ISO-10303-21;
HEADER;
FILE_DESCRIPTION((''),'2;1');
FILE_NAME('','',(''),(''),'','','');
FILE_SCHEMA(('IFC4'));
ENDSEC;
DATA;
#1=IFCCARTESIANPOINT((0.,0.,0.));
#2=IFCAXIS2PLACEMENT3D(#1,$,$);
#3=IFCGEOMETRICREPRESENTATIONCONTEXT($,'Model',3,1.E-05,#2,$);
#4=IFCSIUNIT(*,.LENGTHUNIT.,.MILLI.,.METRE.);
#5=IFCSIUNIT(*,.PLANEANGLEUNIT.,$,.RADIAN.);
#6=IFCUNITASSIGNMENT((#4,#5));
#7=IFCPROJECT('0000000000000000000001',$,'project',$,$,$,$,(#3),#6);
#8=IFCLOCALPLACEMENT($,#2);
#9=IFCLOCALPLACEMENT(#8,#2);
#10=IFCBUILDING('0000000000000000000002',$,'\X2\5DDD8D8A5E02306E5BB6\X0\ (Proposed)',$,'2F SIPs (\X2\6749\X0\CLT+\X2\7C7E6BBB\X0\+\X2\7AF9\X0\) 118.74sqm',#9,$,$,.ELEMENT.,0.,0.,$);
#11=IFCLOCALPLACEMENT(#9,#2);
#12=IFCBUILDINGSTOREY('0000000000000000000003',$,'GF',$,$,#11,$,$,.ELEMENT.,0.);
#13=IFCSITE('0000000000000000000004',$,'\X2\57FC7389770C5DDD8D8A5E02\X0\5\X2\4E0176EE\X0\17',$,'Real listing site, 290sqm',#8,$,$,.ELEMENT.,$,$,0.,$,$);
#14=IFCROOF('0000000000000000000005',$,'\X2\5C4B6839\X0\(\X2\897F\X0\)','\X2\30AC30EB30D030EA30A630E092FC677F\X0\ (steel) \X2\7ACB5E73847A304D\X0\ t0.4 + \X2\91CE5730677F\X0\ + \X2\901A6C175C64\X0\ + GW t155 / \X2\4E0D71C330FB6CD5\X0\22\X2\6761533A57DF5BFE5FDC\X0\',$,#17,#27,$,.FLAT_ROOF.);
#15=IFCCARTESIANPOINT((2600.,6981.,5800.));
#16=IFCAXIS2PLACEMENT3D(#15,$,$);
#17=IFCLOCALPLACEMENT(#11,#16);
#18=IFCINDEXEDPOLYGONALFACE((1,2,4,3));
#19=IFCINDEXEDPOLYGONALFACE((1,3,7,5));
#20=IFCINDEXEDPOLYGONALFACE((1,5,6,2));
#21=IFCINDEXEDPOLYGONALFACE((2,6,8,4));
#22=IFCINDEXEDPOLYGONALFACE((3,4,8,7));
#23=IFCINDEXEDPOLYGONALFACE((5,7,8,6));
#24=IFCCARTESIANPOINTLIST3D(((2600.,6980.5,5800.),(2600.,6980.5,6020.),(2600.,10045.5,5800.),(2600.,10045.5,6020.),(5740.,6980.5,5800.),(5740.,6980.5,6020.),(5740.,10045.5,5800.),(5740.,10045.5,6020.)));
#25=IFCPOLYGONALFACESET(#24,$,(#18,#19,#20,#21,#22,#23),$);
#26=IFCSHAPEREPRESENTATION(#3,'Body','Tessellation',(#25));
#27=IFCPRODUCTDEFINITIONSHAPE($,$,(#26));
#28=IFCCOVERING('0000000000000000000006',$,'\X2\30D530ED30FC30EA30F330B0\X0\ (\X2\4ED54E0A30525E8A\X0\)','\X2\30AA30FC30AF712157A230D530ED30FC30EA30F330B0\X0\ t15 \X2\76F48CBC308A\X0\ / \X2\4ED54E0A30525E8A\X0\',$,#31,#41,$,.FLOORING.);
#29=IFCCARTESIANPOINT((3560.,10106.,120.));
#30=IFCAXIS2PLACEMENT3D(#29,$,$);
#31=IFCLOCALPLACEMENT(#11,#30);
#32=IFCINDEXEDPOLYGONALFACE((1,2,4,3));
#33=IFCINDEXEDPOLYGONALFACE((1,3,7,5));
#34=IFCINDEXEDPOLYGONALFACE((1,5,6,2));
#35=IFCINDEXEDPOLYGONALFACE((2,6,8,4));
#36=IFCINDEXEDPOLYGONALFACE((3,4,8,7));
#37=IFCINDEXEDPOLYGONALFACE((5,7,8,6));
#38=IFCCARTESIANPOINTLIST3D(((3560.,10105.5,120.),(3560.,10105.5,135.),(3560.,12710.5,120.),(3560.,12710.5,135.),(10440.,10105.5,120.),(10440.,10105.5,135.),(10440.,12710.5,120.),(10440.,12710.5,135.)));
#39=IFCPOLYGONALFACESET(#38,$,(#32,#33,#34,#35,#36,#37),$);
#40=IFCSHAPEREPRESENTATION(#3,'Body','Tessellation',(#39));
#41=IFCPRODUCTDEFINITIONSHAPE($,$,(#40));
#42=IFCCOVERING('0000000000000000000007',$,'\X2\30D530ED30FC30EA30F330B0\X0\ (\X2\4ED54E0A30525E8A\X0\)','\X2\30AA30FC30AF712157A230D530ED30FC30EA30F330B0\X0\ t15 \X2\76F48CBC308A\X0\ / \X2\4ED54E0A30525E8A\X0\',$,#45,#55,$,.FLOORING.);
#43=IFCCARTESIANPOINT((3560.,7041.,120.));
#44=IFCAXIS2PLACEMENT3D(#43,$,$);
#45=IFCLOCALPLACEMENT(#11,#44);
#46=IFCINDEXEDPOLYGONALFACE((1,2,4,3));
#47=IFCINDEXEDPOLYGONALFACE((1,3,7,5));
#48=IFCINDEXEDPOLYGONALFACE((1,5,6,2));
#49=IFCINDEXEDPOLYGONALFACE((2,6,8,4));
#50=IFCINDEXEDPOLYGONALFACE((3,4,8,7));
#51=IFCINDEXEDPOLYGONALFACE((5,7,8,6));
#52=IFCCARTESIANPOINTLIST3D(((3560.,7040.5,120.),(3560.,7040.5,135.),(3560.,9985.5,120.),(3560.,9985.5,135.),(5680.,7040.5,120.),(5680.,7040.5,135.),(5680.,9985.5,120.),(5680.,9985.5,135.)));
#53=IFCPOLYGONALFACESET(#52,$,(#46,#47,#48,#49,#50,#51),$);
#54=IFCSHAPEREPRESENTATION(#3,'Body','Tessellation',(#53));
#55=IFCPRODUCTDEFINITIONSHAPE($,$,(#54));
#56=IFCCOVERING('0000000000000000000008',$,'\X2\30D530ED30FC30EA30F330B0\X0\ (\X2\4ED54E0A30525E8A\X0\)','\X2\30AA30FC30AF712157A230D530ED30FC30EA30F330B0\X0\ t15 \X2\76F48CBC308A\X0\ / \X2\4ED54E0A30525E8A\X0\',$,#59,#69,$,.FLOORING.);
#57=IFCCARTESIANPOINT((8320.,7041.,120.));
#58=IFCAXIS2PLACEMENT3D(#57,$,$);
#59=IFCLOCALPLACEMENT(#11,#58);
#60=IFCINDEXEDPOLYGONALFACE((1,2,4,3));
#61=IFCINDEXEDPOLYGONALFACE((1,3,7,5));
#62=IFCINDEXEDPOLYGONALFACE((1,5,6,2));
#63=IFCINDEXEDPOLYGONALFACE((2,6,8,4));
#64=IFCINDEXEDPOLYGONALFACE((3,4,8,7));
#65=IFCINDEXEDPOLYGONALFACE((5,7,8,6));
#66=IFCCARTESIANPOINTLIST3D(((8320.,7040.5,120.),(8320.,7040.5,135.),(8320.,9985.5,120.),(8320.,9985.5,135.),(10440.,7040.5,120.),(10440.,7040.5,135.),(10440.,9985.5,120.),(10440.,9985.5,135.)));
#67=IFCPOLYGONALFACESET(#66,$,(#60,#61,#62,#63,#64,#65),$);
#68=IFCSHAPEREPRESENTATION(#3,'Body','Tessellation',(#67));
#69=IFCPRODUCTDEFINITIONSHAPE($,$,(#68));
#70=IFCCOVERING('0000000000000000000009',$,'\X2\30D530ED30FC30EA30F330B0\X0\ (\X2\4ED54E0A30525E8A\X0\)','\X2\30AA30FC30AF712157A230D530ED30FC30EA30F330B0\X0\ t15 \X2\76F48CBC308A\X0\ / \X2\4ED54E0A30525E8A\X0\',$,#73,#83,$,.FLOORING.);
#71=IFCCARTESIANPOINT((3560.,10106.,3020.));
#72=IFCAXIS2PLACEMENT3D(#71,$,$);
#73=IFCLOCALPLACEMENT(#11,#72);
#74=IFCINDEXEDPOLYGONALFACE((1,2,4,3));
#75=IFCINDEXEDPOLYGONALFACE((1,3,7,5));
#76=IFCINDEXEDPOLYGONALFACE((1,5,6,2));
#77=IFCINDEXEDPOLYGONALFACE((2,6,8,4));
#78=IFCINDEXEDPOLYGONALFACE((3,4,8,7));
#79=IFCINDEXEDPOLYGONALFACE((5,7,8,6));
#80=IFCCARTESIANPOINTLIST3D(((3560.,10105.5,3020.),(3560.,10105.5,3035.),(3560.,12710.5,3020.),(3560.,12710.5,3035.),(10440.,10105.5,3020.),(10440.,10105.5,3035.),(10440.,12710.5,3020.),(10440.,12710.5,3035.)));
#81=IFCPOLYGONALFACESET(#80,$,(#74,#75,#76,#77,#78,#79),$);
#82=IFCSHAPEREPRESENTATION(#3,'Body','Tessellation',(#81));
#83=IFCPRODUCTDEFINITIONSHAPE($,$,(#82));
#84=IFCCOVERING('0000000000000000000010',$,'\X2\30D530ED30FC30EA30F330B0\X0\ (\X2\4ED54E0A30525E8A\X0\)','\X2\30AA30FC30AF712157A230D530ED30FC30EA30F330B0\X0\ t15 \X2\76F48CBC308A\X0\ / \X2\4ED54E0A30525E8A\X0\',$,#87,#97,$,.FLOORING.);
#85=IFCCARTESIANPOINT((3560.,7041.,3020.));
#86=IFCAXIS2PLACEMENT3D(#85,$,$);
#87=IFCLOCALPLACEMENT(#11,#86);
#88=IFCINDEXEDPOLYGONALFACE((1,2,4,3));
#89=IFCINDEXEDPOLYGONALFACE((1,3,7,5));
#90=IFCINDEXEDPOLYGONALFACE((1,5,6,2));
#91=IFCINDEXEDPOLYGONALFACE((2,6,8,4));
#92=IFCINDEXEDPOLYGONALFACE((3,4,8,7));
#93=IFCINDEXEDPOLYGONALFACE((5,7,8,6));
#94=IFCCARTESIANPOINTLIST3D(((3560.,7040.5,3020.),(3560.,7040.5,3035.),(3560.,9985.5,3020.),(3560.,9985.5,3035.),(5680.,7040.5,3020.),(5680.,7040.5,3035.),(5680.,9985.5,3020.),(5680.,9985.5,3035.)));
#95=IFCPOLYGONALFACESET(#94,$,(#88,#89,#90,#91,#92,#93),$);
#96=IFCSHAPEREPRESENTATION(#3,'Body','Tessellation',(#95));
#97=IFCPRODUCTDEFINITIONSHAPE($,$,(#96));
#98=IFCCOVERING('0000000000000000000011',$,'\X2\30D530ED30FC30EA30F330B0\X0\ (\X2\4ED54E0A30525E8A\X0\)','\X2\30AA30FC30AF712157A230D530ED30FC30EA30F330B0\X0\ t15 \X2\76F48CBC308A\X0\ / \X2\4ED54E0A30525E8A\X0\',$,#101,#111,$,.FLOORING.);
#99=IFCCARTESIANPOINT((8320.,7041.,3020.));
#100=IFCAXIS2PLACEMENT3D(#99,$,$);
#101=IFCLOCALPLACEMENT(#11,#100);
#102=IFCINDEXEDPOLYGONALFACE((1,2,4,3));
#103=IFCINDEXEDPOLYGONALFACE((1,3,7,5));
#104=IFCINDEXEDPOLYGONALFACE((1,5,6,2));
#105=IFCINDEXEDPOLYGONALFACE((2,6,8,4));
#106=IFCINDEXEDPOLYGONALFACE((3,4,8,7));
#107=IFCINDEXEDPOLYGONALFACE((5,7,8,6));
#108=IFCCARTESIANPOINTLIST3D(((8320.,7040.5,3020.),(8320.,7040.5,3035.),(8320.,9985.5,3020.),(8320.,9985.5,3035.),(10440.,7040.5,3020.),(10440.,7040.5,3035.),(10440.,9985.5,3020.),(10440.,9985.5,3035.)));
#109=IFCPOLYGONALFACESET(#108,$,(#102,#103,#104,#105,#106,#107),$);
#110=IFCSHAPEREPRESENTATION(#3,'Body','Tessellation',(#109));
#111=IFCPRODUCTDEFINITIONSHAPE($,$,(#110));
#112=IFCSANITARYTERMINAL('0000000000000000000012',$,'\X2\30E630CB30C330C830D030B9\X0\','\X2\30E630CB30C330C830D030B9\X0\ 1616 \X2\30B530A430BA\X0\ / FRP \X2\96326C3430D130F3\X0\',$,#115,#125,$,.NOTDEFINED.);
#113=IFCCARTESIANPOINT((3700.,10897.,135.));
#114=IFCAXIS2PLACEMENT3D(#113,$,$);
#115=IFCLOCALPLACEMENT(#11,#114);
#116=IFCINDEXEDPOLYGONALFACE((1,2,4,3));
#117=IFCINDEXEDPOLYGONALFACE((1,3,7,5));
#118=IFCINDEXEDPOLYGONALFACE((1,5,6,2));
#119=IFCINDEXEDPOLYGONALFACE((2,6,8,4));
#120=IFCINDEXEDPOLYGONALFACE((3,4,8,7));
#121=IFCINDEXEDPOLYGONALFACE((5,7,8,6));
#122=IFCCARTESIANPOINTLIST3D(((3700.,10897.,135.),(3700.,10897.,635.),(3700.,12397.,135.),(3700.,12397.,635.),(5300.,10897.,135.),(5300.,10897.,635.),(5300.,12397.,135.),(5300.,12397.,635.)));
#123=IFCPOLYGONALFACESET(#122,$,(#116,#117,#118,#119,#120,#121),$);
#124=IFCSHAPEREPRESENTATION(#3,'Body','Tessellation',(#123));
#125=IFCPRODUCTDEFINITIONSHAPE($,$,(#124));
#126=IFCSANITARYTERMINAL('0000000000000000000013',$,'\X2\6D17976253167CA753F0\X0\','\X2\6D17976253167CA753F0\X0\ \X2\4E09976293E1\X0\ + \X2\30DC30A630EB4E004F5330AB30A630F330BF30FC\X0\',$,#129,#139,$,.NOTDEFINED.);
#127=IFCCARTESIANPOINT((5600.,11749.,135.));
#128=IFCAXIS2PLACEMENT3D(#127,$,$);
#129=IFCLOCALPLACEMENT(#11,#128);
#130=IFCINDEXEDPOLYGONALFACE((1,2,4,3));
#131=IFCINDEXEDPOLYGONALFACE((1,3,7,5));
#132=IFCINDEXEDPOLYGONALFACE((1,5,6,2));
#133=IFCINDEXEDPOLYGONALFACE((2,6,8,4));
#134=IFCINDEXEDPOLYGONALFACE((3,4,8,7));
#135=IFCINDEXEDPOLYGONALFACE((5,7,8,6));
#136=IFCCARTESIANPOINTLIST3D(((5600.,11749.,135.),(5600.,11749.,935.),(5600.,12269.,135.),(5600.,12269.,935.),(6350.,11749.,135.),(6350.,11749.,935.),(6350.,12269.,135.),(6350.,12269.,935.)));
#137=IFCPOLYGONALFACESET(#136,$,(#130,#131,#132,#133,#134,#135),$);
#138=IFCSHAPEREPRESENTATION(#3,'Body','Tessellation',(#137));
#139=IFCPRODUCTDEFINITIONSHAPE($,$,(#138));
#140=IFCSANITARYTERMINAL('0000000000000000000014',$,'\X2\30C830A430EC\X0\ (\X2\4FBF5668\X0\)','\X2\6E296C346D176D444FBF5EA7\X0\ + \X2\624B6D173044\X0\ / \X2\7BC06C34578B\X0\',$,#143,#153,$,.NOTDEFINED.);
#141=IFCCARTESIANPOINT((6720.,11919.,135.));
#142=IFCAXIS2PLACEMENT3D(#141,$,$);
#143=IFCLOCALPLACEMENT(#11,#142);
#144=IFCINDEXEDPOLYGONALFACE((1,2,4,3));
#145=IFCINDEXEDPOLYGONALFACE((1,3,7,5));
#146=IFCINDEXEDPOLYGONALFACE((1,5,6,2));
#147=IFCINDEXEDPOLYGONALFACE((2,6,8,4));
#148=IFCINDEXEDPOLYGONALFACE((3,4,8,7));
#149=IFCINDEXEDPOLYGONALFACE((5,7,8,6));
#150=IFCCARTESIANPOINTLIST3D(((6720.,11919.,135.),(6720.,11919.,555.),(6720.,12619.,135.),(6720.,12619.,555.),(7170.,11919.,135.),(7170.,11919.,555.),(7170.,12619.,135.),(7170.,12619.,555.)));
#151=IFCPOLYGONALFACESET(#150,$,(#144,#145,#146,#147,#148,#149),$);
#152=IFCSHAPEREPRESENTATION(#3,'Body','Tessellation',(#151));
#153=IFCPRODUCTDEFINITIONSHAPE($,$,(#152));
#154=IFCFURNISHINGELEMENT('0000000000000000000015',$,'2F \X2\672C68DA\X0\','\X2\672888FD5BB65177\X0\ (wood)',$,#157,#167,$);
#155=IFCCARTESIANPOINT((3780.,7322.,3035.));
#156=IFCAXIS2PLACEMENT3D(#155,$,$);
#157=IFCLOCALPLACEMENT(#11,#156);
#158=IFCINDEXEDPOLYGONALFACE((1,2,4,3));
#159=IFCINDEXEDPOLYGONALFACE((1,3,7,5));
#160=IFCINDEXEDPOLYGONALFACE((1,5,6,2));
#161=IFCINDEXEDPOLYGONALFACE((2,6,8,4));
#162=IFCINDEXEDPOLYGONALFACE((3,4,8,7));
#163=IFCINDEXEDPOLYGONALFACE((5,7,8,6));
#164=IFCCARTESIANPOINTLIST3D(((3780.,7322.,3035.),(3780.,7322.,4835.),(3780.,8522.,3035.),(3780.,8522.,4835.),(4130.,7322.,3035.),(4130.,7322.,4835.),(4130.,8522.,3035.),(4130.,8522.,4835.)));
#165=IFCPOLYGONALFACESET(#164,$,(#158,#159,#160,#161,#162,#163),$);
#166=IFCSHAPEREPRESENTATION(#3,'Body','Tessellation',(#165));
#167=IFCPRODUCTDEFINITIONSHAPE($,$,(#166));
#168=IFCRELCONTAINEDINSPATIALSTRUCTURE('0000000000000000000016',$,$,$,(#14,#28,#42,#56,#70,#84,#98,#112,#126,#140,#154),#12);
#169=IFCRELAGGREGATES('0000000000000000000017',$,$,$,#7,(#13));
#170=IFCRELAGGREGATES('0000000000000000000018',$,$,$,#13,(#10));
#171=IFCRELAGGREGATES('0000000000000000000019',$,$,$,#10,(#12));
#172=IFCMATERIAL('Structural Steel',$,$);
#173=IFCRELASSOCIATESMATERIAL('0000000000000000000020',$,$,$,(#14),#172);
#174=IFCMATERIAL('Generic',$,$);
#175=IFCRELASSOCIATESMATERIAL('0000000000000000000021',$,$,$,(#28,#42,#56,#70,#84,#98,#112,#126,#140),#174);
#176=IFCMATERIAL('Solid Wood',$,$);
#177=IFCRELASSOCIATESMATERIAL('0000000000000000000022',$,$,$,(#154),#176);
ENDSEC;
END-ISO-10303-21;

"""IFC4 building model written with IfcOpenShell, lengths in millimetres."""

from ifc_helpers import new_model, si_unit, frame, frame_2d, origin, place, context, project, spatial, rectangle, extrude, material, element, save


model = new_model("IFC4")

# Units and contexts
model_context = context("Model", 3, precision=1e-05, world=origin())
ifc_project = project(units=[si_unit("LENGTHUNIT", "METRE", prefix="MILLI"), si_unit("PLANEANGLEUNIT", "RADIAN")], contexts=[model_context])

# Site, building, storey
site_placement = place(None, origin())
site = spatial("IfcSite", under=ifc_project, at=site_placement, Name="埼玉県川越市5丁目17", ObjectType="Real listing site, 290sqm", CompositionType="ELEMENT", RefElevation=0.0)
building_placement = place(site_placement, origin())
building = spatial("IfcBuilding", under=site, at=building_placement, Name="川越市の家 (Proposed)", ObjectType="2F SIPs (杉CLT+籾殻+竹) 118.74sqm", CompositionType="ELEMENT", ElevationOfRefHeight=0.0, ElevationOfTerrain=0.0)
storey_placement = place(building_placement, origin())
storey = spatial("IfcBuildingStorey", under=building, at=storey_placement, Name="GF", CompositionType="ELEMENT", Elevation=0.0)

# Shared definitions
ifc_material_1 = material(Name="Solid Wood")

# Shared definitions
ifc_material_2 = material(Name="Generic")

# Roof
ifc_material_3 = material(Name="Structural Steel")
roof_1_placement = place(storey_placement, frame((2600.0, 6981.0, 5800.0)))
element("IfcRoof", 1, at=roof_1_placement, inside=storey, material=ifc_material_3, Name="屋根(西)", Description="ガルバリウム鋼板 (steel) 立平葺き t0.4 + 野地板 + 通気層 + GW t155 / 不燃・法22条区域対応", PredefinedType="FLAT_ROOF", context=model_context, shape_type="SweptSolid", body=[
    extrude(rectangle(XDim=3140.0, YDim=3065.0, at=frame_2d((1570.0, 1532.0))), frame((2600.0, 6981.0, 5800.0)), (0.0, 0.0, 1.0), 220.0),
])

# Coverings
covering_1_placement = place(storey_placement, frame((3560.0, 10106.0, 120.0)))
element("IfcCovering", 2, at=covering_1_placement, inside=storey, material=ifc_material_2, Name="フローリング (仕上げ床)", Description="オーク無垢フローリング t15 直貼り / 仕上げ床", PredefinedType="FLOORING", context=model_context, shape_type="SweptSolid", body=[
    extrude(rectangle(XDim=6880.0, YDim=2605.0, at=frame_2d((3440.0, 1302.0))), frame((3560.0, 10106.0, 120.0)), (0.0, 0.0, 1.0), 15.0),
])
covering_2_placement = place(storey_placement, frame((3560.0, 7041.0, 120.0)))
element("IfcCovering", 3, at=covering_2_placement, inside=storey, material=ifc_material_2, Name="フローリング (仕上げ床)", Description="オーク無垢フローリング t15 直貼り / 仕上げ床", PredefinedType="FLOORING", context=model_context, shape_type="SweptSolid", body=[
    extrude(rectangle(XDim=2120.0, YDim=2945.0, at=frame_2d((1060.0, 1472.0))), frame((3560.0, 7041.0, 120.0)), (0.0, 0.0, 1.0), 15.0),
])
covering_3_placement = place(storey_placement, frame((8320.0, 7041.0, 120.0)))
element("IfcCovering", 4, at=covering_3_placement, inside=storey, material=ifc_material_2, Name="フローリング (仕上げ床)", Description="オーク無垢フローリング t15 直貼り / 仕上げ床", PredefinedType="FLOORING", context=model_context, shape_type="SweptSolid", body=[
    extrude(rectangle(XDim=2120.0, YDim=2945.0, at=frame_2d((1060.0, 1472.0))), frame((8320.0, 7041.0, 120.0)), (0.0, 0.0, 1.0), 15.0),
])
covering_4_placement = place(storey_placement, frame((3560.0, 10106.0, 3020.0)))
element("IfcCovering", 5, at=covering_4_placement, inside=storey, material=ifc_material_2, Name="フローリング (仕上げ床)", Description="オーク無垢フローリング t15 直貼り / 仕上げ床", PredefinedType="FLOORING", context=model_context, shape_type="SweptSolid", body=[
    extrude(rectangle(XDim=6880.0, YDim=2605.0, at=frame_2d((3440.0, 1302.0))), frame((3560.0, 10106.0, 3020.0)), (0.0, 0.0, 1.0), 15.0),
])
covering_5_placement = place(storey_placement, frame((3560.0, 7041.0, 3020.0)))
element("IfcCovering", 6, at=covering_5_placement, inside=storey, material=ifc_material_2, Name="フローリング (仕上げ床)", Description="オーク無垢フローリング t15 直貼り / 仕上げ床", PredefinedType="FLOORING", context=model_context, shape_type="SweptSolid", body=[
    extrude(rectangle(XDim=2120.0, YDim=2945.0, at=frame_2d((1060.0, 1472.0))), frame((3560.0, 7041.0, 3020.0)), (0.0, 0.0, 1.0), 15.0),
])
covering_6_placement = place(storey_placement, frame((8320.0, 7041.0, 3020.0)))
element("IfcCovering", 7, at=covering_6_placement, inside=storey, material=ifc_material_2, Name="フローリング (仕上げ床)", Description="オーク無垢フローリング t15 直貼り / 仕上げ床", PredefinedType="FLOORING", context=model_context, shape_type="SweptSolid", body=[
    extrude(rectangle(XDim=2120.0, YDim=2945.0, at=frame_2d((1060.0, 1472.0))), frame((8320.0, 7041.0, 3020.0)), (0.0, 0.0, 1.0), 15.0),
])

# Sanitary terminals
sanitary_terminal_1_placement = place(storey_placement, frame((3700.0, 10897.0, 135.0)))
element("IfcSanitaryTerminal", 8, at=sanitary_terminal_1_placement, inside=storey, material=ifc_material_2, Name="ユニットバス", Description="ユニットバス 1616 サイズ / FRP 防水パン", PredefinedType="NOTDEFINED", context=model_context, shape_type="SweptSolid", body=[
    extrude(rectangle(XDim=1600.0, YDim=1500.0, at=frame_2d((800.0, 750.0))), frame((3700.0, 10897.0, 135.0)), (0.0, 0.0, 1.0), 500.0),
])
sanitary_terminal_2_placement = place(storey_placement, frame((5600.0, 11749.0, 135.0)))
element("IfcSanitaryTerminal", 9, at=sanitary_terminal_2_placement, inside=storey, material=ifc_material_2, Name="洗面化粧台", Description="洗面化粧台 三面鏡 + ボウル一体カウンター", PredefinedType="NOTDEFINED", context=model_context, shape_type="SweptSolid", body=[
    extrude(rectangle(XDim=750.0, YDim=520.0, at=frame_2d((375.0, 260.0))), frame((5600.0, 11749.0, 135.0)), (0.0, 0.0, 1.0), 800.0),
])
sanitary_terminal_3_placement = place(storey_placement, frame((6720.0, 11919.0, 135.0)))
element("IfcSanitaryTerminal", 10, at=sanitary_terminal_3_placement, inside=storey, material=ifc_material_2, Name="トイレ (便器)", Description="温水洗浄便座 + 手洗い / 節水型", PredefinedType="NOTDEFINED", context=model_context, shape_type="SweptSolid", body=[
    extrude(rectangle(XDim=450.0, YDim=700.0, at=frame_2d((225.0, 350.0))), frame((6720.0, 11919.0, 135.0)), (0.0, 0.0, 1.0), 420.0),
])

# Furnishing element
furnishing_placement = place(storey_placement, frame((3780.0, 7322.0, 3035.0)))
element("IfcFurnishingElement", 11, at=furnishing_placement, inside=storey, material=ifc_material_1, Name="2F 本棚", Description="木製家具 (wood)", context=model_context, shape_type="SweptSolid", body=[
    extrude(rectangle(XDim=350.0, YDim=1200.0, at=frame_2d((175.0, 600.0))), frame((3780.0, 7322.0, 3035.0)), (0.0, 0.0, 1.0), 1800.0),
])

save(model, "model.ifc")
